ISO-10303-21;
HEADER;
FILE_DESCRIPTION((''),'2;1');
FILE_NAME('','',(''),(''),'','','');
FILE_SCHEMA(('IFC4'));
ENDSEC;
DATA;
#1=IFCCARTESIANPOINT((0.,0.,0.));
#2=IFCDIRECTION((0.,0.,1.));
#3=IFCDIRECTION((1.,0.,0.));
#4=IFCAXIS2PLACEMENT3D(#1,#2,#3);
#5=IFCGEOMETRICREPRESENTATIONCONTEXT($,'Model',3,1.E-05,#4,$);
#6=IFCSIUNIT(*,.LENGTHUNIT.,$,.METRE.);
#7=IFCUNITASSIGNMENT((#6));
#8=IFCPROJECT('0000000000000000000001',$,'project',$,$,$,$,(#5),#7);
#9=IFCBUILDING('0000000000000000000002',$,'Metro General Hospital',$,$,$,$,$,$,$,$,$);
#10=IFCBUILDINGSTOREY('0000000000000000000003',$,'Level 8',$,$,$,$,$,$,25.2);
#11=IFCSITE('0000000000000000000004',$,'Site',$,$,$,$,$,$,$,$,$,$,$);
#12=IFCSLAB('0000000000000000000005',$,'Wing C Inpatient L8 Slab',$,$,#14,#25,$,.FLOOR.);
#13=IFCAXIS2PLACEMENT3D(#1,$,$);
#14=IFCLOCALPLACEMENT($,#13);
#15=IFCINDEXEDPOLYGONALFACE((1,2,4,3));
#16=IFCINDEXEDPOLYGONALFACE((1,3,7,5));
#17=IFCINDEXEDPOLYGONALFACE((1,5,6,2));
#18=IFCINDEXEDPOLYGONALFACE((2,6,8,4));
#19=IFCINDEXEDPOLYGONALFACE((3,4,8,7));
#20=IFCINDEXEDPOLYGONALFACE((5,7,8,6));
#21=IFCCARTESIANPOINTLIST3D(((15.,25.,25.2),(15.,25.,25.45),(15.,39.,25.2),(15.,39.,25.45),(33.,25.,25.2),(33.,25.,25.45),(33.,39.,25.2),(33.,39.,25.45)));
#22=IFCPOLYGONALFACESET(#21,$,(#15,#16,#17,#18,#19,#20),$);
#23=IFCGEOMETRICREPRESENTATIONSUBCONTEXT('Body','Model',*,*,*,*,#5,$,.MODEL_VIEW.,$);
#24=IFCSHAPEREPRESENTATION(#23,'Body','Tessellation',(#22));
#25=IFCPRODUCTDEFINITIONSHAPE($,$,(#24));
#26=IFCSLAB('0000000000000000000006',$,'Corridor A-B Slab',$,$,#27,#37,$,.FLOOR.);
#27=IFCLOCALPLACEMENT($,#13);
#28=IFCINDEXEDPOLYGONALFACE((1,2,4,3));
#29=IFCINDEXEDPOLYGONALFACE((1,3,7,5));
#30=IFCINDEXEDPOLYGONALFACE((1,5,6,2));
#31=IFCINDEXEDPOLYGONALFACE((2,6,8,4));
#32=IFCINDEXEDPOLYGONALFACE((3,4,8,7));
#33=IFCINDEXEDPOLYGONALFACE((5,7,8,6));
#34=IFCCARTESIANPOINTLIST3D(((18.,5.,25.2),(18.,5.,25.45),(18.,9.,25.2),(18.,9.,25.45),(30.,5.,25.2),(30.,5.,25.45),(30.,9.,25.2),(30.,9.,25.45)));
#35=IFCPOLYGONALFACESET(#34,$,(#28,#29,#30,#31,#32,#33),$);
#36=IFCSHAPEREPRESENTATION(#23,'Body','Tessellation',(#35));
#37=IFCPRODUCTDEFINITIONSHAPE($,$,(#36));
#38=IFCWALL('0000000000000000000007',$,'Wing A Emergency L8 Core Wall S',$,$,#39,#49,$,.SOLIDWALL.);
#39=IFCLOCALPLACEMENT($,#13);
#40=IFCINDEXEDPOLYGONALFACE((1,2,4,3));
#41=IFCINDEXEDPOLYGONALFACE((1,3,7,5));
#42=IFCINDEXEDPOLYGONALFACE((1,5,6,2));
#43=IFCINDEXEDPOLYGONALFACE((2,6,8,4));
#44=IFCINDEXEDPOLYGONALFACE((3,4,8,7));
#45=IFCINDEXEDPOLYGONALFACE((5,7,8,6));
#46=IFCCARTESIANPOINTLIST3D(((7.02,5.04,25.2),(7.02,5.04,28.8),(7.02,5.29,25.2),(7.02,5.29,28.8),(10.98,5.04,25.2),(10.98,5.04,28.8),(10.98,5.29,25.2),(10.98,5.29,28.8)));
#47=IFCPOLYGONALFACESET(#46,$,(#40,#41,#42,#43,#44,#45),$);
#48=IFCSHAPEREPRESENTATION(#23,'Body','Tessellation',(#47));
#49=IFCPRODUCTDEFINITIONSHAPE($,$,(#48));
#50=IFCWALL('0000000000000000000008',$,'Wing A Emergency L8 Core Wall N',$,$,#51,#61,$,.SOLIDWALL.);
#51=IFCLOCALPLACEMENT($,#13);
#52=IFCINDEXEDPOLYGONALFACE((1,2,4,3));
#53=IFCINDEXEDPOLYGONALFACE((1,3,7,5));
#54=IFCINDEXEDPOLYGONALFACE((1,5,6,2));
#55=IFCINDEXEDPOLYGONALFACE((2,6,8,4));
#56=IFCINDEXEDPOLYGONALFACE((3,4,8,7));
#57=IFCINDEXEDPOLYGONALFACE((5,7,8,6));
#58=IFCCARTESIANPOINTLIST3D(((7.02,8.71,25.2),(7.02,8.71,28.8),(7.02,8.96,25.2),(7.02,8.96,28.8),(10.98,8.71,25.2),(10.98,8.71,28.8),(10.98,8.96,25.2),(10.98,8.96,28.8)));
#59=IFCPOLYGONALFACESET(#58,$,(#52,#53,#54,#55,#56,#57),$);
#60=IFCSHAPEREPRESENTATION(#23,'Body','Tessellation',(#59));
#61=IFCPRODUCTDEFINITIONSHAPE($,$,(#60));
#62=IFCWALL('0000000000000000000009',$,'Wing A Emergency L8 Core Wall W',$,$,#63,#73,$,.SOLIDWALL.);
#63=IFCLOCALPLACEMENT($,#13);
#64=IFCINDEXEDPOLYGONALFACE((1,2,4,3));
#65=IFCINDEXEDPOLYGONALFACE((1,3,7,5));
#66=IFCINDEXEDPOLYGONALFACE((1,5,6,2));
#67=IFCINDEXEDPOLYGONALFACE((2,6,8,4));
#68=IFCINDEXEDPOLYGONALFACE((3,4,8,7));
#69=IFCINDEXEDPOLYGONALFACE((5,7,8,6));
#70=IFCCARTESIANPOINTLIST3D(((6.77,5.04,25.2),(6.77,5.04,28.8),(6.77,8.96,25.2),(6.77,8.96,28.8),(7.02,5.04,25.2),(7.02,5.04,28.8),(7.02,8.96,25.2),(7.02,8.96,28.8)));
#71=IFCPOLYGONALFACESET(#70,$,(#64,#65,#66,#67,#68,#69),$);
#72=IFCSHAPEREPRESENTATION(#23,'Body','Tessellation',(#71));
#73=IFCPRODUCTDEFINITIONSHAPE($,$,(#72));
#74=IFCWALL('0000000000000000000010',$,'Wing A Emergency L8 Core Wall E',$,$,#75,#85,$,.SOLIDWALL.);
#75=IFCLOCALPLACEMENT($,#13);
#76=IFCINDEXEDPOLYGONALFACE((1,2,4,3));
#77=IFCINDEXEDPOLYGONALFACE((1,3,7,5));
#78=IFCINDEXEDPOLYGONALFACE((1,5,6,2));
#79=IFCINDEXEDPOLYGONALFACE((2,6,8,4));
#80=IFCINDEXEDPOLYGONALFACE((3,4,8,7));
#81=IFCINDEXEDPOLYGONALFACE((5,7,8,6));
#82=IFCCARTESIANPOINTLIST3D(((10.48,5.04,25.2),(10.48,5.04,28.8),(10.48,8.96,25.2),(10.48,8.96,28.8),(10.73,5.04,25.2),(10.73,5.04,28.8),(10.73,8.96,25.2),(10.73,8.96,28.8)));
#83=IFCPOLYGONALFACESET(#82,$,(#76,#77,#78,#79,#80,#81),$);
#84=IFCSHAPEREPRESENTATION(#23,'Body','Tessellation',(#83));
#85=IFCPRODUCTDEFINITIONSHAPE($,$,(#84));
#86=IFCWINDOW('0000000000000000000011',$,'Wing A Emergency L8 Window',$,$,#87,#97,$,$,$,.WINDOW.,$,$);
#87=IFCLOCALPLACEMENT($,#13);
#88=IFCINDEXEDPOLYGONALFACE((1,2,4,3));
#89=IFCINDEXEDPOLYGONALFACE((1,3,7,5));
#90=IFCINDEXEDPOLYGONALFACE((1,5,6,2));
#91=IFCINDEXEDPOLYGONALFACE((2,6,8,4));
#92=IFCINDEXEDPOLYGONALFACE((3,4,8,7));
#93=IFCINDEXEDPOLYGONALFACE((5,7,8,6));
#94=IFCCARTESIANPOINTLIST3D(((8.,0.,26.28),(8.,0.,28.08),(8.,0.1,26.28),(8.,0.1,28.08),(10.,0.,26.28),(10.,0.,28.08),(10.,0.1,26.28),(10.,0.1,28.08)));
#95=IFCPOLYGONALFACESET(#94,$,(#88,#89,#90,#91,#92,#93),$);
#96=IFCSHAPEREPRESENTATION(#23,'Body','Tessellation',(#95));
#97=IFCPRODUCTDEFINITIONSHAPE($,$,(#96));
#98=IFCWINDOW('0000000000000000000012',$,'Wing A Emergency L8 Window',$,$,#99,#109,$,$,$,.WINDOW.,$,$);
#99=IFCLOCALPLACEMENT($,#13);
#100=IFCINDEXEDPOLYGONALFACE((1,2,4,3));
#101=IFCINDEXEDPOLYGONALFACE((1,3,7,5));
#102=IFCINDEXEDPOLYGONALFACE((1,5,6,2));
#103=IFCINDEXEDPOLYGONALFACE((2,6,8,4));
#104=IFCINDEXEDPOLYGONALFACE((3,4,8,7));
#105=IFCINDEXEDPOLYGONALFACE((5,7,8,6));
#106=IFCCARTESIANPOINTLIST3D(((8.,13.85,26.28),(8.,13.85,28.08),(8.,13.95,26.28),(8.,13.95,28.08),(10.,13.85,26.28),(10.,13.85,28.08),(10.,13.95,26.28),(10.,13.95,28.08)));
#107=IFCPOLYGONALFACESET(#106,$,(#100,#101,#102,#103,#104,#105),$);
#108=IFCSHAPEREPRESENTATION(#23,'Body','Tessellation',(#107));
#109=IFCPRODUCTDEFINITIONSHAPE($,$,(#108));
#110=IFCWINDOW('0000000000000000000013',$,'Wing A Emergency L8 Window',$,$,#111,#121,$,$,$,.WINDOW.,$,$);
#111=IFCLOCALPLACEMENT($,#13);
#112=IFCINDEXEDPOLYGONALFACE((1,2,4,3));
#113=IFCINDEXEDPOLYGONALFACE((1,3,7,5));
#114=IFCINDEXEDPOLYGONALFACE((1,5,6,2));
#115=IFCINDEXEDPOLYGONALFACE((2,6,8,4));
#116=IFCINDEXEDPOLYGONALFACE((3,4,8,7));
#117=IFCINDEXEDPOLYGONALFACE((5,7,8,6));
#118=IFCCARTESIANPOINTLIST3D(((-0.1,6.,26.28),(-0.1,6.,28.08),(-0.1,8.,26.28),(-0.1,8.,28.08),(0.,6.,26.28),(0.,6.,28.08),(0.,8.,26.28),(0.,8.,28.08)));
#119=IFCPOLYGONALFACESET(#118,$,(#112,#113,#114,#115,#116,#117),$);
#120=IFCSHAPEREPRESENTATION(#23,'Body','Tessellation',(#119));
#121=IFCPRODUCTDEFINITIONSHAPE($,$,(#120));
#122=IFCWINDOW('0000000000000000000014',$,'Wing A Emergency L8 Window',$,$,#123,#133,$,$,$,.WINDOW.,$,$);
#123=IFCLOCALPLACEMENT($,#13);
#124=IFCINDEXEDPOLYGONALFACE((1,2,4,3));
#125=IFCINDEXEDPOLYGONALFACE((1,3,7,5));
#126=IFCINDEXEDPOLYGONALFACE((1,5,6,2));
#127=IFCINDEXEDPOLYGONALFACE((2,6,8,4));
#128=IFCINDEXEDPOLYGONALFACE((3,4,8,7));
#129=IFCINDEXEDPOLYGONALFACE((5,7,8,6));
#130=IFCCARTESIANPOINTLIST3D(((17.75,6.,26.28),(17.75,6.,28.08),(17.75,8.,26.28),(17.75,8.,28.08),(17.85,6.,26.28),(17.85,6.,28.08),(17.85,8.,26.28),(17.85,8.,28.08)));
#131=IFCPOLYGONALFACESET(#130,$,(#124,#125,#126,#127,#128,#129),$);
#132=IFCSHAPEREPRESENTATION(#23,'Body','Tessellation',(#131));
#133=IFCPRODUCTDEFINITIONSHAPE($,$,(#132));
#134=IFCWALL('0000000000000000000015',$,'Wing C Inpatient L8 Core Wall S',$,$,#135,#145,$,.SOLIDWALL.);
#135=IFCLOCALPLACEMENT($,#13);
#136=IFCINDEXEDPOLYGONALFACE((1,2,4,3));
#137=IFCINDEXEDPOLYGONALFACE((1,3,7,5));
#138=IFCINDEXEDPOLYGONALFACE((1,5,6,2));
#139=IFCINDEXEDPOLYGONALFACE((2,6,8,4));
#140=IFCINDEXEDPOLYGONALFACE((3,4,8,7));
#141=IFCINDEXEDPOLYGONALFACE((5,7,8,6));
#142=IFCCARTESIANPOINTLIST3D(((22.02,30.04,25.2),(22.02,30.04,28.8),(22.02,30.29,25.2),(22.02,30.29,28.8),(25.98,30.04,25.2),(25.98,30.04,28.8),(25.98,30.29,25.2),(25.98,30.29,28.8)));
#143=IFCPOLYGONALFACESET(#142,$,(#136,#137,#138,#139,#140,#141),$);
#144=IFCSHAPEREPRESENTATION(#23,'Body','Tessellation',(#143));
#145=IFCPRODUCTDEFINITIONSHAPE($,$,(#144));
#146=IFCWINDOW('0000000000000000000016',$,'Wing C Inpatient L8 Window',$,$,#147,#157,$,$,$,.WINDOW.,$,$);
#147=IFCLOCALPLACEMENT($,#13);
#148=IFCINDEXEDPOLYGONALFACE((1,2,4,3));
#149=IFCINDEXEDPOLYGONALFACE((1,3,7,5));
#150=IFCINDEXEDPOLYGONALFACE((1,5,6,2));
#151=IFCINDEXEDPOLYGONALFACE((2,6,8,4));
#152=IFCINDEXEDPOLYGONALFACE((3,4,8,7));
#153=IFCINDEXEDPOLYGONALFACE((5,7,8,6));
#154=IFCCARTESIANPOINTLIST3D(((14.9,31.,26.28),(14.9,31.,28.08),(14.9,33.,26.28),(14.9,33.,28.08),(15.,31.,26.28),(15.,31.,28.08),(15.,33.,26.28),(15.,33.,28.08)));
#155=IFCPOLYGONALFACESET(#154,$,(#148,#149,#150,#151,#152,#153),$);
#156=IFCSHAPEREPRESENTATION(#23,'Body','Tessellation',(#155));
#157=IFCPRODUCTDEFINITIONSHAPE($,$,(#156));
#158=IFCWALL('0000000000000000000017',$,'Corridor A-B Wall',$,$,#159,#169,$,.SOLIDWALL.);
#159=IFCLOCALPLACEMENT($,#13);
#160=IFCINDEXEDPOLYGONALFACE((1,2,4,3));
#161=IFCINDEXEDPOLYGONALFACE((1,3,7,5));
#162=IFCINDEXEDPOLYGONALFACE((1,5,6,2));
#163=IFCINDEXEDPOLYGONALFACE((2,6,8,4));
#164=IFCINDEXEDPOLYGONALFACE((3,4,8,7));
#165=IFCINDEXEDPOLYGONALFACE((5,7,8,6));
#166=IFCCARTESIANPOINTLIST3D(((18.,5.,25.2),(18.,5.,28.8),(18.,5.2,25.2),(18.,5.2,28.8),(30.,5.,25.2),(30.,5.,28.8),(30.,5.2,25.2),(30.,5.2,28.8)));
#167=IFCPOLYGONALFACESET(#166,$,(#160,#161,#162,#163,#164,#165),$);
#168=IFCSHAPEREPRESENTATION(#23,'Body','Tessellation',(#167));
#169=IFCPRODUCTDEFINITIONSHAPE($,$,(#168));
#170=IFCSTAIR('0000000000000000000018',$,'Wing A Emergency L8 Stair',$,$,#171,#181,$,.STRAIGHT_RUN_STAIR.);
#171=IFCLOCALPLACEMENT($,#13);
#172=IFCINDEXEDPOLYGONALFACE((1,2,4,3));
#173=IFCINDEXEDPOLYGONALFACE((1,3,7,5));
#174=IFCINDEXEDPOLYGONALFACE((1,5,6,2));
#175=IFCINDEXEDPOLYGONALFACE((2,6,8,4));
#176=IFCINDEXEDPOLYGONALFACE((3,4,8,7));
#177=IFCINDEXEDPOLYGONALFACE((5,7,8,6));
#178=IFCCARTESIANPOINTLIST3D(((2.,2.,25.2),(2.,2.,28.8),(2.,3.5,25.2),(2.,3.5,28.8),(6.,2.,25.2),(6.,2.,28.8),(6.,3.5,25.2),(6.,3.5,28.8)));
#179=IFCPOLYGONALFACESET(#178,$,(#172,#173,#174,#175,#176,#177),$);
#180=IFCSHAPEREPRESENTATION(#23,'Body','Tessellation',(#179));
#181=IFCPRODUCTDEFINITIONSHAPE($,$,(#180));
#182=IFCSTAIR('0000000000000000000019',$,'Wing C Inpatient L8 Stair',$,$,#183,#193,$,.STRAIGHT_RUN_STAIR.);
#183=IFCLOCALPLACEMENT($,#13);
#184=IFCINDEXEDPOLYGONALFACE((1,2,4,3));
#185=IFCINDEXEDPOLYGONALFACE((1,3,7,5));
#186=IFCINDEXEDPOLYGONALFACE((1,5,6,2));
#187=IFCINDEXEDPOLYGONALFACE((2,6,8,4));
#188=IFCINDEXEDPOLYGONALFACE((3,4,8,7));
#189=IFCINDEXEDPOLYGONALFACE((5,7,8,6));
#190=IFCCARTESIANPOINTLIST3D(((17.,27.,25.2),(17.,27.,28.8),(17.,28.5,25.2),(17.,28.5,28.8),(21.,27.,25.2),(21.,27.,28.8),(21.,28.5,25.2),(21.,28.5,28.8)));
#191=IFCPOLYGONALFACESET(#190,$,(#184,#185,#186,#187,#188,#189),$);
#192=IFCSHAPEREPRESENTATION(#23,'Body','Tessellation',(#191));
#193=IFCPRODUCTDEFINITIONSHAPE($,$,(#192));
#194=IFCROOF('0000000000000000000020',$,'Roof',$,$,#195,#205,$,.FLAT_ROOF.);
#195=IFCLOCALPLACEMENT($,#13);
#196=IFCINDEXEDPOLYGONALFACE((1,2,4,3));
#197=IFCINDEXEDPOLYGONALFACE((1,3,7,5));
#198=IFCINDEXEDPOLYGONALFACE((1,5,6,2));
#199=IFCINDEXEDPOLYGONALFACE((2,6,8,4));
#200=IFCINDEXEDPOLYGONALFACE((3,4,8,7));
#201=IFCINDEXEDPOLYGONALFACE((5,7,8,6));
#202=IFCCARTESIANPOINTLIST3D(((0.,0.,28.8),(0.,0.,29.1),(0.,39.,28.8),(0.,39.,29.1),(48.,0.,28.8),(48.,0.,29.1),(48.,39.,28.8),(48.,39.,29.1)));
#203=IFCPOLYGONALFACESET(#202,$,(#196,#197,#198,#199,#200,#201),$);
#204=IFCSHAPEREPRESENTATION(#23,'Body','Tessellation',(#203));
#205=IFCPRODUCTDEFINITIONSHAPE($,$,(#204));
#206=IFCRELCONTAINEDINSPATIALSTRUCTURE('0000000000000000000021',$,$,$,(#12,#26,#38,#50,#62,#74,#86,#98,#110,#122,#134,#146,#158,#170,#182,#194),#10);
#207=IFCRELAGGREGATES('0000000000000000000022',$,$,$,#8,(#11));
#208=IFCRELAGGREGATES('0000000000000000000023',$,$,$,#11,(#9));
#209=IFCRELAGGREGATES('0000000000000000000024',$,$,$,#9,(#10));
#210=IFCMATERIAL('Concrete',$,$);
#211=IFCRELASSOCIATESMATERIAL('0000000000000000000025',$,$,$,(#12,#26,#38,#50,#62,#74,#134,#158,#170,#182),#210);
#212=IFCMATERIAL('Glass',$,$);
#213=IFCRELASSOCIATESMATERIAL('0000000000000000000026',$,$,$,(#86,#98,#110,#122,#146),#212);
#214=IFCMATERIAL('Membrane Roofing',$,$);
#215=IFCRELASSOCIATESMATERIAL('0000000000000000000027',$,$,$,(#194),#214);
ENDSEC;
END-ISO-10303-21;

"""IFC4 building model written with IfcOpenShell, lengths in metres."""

from ifc_helpers import new_model, si_unit, frame, origin_with_axes, place, context, subcontext, project, spatial, line, indexed_curve, outline, extrude, material, element, save


model = new_model("IFC4")

# Units and contexts
model_context = context("Model", 3, precision=1e-05, world=origin_with_axes())
body_context = subcontext(model_context, "Body", "Model", "MODEL_VIEW")
ifc_project = project(units=[si_unit("LENGTHUNIT", "METRE")], contexts=[model_context])

# Site, building, storey
site = spatial("IfcSite", under=ifc_project, Name="Site")
building = spatial("IfcBuilding", under=site, Name="Metro General Hospital")
storey = spatial("IfcBuildingStorey", under=building, Name="Level 8", Elevation=25.2)

# Slabs
ifc_material_1 = material(Name="Concrete")
for number, where, z_axis, x_axis, name in (
    (1, (15.0, 25.0, 25.2), (0.0, 0.0, 1.0), (1.0, 0.0, 0.0), "Wing C Inpatient L8 Slab"),
):
    element("IfcSlab", number, at=place(None, frame(where, z_axis=z_axis, x_axis=x_axis)), inside=storey, material=ifc_material_1, Name=name, PredefinedType="FLOOR", context=body_context, shape_type="SweptSolid", body=[
        extrude(outline(indexed_curve([(0.0, 0.0), (18.0, 0.0), (18.0, 14.0), (0.0, 14.0)], segments=[line(1, 2, 3, 4, 1)])), origin_with_axes(), (0.0, 0.0, 1.0), 0.25),
    ])
slab_placement = place(None, frame((18.0, 5.0, 25.2), z_axis=(0.0, 0.0, 1.0), x_axis=(1.0, 0.0, 0.0)))
element("IfcSlab", 2, at=slab_placement, inside=storey, material=ifc_material_1, Name="Corridor A-B Slab", PredefinedType="FLOOR", context=body_context, shape_type="SweptSolid", body=[
    extrude(outline(indexed_curve([(0.0, 0.0), (12.0, 0.0), (12.0, 4.0), (0.0, 4.0)], segments=[line(1, 2, 3, 4, 1)])), origin_with_axes(), (0.0, 0.0, 1.0), 0.25),
])

# Walls
for number, where, z_axis, x_axis, name in (
    (3, (7.02, 5.04, 25.2), (0.0, 0.0, 1.0), (1.0, 0.0, 0.0), "Wing A Emergency L8 Core Wall S"),
    (4, (7.02, 8.71, 25.2), (0.0, 0.0, 1.0), (1.0, 0.0, 0.0), "Wing A Emergency L8 Core Wall N"),
):
    element("IfcWall", number, at=place(None, frame(where, z_axis=z_axis, x_axis=x_axis)), inside=storey, material=ifc_material_1, Name=name, PredefinedType="SOLIDWALL", context=body_context, shape_type="SweptSolid", body=[
        extrude(outline(indexed_curve([(0.0, 0.0), (3.96, 0.0), (3.96, 0.25), (0.0, 0.25)], segments=[line(1, 2, 3, 4, 1)])), origin_with_axes(), (0.0, 0.0, 1.0), 3.6),
    ])
for number, where, z_axis, x_axis, name in (
    (5, (7.02, 5.04, 25.2), (0.0, 0.0, 1.0), (0.0, 1.0, 0.0), "Wing A Emergency L8 Core Wall W"),
    (6, (10.73, 5.04, 25.2), (0.0, 0.0, 1.0), (0.0, 1.0, 0.0), "Wing A Emergency L8 Core Wall E"),
):
    element("IfcWall", number, at=place(None, frame(where, z_axis=z_axis, x_axis=x_axis)), inside=storey, material=ifc_material_1, Name=name, PredefinedType="SOLIDWALL", context=body_context, shape_type="SweptSolid", body=[
        extrude(outline(indexed_curve([(0.0, 0.0), (3.92, 0.0), (3.92, 0.25), (0.0, 0.25)], segments=[line(1, 2, 3, 4, 1)])), origin_with_axes(), (0.0, 0.0, 1.0), 3.6),
    ])

# Windows
ifc_material_2 = material(Name="Glass")
for number, where, z_axis, x_axis, name in (
    (7, (8.0, 0.0, 26.28), (0.0, 0.0, 1.0), (1.0, 0.0, 0.0), "Wing A Emergency L8 Window"),
    (8, (8.0, 13.85, 26.28), (0.0, 0.0, 1.0), (1.0, 0.0, 0.0), "Wing A Emergency L8 Window"),
    (9, (0.0, 6.0, 26.28), (0.0, 0.0, 1.0), (0.0, 1.0, 0.0), "Wing A Emergency L8 Window"),
    (10, (17.85, 6.0, 26.28), (0.0, 0.0, 1.0), (0.0, 1.0, 0.0), "Wing A Emergency L8 Window"),
):
    element("IfcWindow", number, at=place(None, frame(where, z_axis=z_axis, x_axis=x_axis)), inside=storey, material=ifc_material_2, Name=name, PredefinedType="WINDOW", context=body_context, shape_type="SweptSolid", body=[
        extrude(outline(indexed_curve([(0.0, 0.0), (2.0, 0.0), (2.0, 0.1), (0.0, 0.1)], segments=[line(1, 2, 3, 4, 1)])), origin_with_axes(), (0.0, 0.0, 1.0), 1.8),
    ])

# Wall
wall_1_placement = place(None, frame((22.02, 30.04, 25.2), z_axis=(0.0, 0.0, 1.0), x_axis=(1.0, 0.0, 0.0)))
element("IfcWall", 11, at=wall_1_placement, inside=storey, material=ifc_material_1, Name="Wing C Inpatient L8 Core Wall S", PredefinedType="SOLIDWALL", context=body_context, shape_type="SweptSolid", body=[
    extrude(outline(indexed_curve([(0.0, 0.0), (3.96, 0.0), (3.96, 0.25), (0.0, 0.25)], segments=[line(1, 2, 3, 4, 1)])), origin_with_axes(), (0.0, 0.0, 1.0), 3.6),
])

# Window
window_placement = place(None, frame((15.0, 31.0, 26.28), z_axis=(0.0, 0.0, 1.0), x_axis=(0.0, 1.0, 0.0)))
element("IfcWindow", 12, at=window_placement, inside=storey, material=ifc_material_2, Name="Wing C Inpatient L8 Window", PredefinedType="WINDOW", context=body_context, shape_type="SweptSolid", body=[
    extrude(outline(indexed_curve([(0.0, 0.0), (2.0, 0.0), (2.0, 0.1), (0.0, 0.1)], segments=[line(1, 2, 3, 4, 1)])), origin_with_axes(), (0.0, 0.0, 1.0), 1.8),
])

# Wall
wall_2_placement = place(None, frame((18.0, 5.0, 25.2), z_axis=(0.0, 0.0, 1.0), x_axis=(1.0, 0.0, 0.0)))
element("IfcWall", 13, at=wall_2_placement, inside=storey, material=ifc_material_1, Name="Corridor A-B Wall", PredefinedType="SOLIDWALL", context=body_context, shape_type="SweptSolid", body=[
    extrude(outline(indexed_curve([(0.0, 0.0), (12.0, 0.0), (12.0, 0.2), (0.0, 0.2)], segments=[line(1, 2, 3, 4, 1)])), origin_with_axes(), (0.0, 0.0, 1.0), 3.6),
])

# Stairs
for number, where, z_axis, x_axis, name in (
    (14, (2.0, 2.0, 25.2), (0.0, 0.0, 1.0), (1.0, 0.0, 0.0), "Wing A Emergency L8 Stair"),
    (15, (17.0, 27.0, 25.2), (0.0, 0.0, 1.0), (1.0, 0.0, 0.0), "Wing C Inpatient L8 Stair"),
):
    element("IfcStair", number, at=place(None, frame(where, z_axis=z_axis, x_axis=x_axis)), inside=storey, material=ifc_material_1, Name=name, PredefinedType="STRAIGHT_RUN_STAIR", context=body_context, shape_type="SweptSolid", body=[
        extrude(outline(indexed_curve([(0.0, 0.0), (4.0, 0.0), (4.0, 1.5), (0.0, 1.5)], segments=[line(1, 2, 3, 4, 1)])), origin_with_axes(), (0.0, 0.0, 1.0), 3.6),
    ])

# Roof
ifc_material_3 = material(Name="Membrane Roofing")
roof_placement = place(None, frame((0.0, 0.0, 28.8), z_axis=(0.0, 0.0, 1.0), x_axis=(1.0, 0.0, 0.0)))
element("IfcRoof", 16, at=roof_placement, inside=storey, material=ifc_material_3, Name="Roof", PredefinedType="FLAT_ROOF", context=body_context, shape_type="SweptSolid", body=[
    extrude(outline(indexed_curve([(0.0, 0.0), (48.0, 0.0), (48.0, 39.0), (0.0, 39.0)], segments=[line(1, 2, 3, 4, 1)])), origin_with_axes(), (0.0, 0.0, 1.0), 0.3),
])

save(model, "model.ifc")
